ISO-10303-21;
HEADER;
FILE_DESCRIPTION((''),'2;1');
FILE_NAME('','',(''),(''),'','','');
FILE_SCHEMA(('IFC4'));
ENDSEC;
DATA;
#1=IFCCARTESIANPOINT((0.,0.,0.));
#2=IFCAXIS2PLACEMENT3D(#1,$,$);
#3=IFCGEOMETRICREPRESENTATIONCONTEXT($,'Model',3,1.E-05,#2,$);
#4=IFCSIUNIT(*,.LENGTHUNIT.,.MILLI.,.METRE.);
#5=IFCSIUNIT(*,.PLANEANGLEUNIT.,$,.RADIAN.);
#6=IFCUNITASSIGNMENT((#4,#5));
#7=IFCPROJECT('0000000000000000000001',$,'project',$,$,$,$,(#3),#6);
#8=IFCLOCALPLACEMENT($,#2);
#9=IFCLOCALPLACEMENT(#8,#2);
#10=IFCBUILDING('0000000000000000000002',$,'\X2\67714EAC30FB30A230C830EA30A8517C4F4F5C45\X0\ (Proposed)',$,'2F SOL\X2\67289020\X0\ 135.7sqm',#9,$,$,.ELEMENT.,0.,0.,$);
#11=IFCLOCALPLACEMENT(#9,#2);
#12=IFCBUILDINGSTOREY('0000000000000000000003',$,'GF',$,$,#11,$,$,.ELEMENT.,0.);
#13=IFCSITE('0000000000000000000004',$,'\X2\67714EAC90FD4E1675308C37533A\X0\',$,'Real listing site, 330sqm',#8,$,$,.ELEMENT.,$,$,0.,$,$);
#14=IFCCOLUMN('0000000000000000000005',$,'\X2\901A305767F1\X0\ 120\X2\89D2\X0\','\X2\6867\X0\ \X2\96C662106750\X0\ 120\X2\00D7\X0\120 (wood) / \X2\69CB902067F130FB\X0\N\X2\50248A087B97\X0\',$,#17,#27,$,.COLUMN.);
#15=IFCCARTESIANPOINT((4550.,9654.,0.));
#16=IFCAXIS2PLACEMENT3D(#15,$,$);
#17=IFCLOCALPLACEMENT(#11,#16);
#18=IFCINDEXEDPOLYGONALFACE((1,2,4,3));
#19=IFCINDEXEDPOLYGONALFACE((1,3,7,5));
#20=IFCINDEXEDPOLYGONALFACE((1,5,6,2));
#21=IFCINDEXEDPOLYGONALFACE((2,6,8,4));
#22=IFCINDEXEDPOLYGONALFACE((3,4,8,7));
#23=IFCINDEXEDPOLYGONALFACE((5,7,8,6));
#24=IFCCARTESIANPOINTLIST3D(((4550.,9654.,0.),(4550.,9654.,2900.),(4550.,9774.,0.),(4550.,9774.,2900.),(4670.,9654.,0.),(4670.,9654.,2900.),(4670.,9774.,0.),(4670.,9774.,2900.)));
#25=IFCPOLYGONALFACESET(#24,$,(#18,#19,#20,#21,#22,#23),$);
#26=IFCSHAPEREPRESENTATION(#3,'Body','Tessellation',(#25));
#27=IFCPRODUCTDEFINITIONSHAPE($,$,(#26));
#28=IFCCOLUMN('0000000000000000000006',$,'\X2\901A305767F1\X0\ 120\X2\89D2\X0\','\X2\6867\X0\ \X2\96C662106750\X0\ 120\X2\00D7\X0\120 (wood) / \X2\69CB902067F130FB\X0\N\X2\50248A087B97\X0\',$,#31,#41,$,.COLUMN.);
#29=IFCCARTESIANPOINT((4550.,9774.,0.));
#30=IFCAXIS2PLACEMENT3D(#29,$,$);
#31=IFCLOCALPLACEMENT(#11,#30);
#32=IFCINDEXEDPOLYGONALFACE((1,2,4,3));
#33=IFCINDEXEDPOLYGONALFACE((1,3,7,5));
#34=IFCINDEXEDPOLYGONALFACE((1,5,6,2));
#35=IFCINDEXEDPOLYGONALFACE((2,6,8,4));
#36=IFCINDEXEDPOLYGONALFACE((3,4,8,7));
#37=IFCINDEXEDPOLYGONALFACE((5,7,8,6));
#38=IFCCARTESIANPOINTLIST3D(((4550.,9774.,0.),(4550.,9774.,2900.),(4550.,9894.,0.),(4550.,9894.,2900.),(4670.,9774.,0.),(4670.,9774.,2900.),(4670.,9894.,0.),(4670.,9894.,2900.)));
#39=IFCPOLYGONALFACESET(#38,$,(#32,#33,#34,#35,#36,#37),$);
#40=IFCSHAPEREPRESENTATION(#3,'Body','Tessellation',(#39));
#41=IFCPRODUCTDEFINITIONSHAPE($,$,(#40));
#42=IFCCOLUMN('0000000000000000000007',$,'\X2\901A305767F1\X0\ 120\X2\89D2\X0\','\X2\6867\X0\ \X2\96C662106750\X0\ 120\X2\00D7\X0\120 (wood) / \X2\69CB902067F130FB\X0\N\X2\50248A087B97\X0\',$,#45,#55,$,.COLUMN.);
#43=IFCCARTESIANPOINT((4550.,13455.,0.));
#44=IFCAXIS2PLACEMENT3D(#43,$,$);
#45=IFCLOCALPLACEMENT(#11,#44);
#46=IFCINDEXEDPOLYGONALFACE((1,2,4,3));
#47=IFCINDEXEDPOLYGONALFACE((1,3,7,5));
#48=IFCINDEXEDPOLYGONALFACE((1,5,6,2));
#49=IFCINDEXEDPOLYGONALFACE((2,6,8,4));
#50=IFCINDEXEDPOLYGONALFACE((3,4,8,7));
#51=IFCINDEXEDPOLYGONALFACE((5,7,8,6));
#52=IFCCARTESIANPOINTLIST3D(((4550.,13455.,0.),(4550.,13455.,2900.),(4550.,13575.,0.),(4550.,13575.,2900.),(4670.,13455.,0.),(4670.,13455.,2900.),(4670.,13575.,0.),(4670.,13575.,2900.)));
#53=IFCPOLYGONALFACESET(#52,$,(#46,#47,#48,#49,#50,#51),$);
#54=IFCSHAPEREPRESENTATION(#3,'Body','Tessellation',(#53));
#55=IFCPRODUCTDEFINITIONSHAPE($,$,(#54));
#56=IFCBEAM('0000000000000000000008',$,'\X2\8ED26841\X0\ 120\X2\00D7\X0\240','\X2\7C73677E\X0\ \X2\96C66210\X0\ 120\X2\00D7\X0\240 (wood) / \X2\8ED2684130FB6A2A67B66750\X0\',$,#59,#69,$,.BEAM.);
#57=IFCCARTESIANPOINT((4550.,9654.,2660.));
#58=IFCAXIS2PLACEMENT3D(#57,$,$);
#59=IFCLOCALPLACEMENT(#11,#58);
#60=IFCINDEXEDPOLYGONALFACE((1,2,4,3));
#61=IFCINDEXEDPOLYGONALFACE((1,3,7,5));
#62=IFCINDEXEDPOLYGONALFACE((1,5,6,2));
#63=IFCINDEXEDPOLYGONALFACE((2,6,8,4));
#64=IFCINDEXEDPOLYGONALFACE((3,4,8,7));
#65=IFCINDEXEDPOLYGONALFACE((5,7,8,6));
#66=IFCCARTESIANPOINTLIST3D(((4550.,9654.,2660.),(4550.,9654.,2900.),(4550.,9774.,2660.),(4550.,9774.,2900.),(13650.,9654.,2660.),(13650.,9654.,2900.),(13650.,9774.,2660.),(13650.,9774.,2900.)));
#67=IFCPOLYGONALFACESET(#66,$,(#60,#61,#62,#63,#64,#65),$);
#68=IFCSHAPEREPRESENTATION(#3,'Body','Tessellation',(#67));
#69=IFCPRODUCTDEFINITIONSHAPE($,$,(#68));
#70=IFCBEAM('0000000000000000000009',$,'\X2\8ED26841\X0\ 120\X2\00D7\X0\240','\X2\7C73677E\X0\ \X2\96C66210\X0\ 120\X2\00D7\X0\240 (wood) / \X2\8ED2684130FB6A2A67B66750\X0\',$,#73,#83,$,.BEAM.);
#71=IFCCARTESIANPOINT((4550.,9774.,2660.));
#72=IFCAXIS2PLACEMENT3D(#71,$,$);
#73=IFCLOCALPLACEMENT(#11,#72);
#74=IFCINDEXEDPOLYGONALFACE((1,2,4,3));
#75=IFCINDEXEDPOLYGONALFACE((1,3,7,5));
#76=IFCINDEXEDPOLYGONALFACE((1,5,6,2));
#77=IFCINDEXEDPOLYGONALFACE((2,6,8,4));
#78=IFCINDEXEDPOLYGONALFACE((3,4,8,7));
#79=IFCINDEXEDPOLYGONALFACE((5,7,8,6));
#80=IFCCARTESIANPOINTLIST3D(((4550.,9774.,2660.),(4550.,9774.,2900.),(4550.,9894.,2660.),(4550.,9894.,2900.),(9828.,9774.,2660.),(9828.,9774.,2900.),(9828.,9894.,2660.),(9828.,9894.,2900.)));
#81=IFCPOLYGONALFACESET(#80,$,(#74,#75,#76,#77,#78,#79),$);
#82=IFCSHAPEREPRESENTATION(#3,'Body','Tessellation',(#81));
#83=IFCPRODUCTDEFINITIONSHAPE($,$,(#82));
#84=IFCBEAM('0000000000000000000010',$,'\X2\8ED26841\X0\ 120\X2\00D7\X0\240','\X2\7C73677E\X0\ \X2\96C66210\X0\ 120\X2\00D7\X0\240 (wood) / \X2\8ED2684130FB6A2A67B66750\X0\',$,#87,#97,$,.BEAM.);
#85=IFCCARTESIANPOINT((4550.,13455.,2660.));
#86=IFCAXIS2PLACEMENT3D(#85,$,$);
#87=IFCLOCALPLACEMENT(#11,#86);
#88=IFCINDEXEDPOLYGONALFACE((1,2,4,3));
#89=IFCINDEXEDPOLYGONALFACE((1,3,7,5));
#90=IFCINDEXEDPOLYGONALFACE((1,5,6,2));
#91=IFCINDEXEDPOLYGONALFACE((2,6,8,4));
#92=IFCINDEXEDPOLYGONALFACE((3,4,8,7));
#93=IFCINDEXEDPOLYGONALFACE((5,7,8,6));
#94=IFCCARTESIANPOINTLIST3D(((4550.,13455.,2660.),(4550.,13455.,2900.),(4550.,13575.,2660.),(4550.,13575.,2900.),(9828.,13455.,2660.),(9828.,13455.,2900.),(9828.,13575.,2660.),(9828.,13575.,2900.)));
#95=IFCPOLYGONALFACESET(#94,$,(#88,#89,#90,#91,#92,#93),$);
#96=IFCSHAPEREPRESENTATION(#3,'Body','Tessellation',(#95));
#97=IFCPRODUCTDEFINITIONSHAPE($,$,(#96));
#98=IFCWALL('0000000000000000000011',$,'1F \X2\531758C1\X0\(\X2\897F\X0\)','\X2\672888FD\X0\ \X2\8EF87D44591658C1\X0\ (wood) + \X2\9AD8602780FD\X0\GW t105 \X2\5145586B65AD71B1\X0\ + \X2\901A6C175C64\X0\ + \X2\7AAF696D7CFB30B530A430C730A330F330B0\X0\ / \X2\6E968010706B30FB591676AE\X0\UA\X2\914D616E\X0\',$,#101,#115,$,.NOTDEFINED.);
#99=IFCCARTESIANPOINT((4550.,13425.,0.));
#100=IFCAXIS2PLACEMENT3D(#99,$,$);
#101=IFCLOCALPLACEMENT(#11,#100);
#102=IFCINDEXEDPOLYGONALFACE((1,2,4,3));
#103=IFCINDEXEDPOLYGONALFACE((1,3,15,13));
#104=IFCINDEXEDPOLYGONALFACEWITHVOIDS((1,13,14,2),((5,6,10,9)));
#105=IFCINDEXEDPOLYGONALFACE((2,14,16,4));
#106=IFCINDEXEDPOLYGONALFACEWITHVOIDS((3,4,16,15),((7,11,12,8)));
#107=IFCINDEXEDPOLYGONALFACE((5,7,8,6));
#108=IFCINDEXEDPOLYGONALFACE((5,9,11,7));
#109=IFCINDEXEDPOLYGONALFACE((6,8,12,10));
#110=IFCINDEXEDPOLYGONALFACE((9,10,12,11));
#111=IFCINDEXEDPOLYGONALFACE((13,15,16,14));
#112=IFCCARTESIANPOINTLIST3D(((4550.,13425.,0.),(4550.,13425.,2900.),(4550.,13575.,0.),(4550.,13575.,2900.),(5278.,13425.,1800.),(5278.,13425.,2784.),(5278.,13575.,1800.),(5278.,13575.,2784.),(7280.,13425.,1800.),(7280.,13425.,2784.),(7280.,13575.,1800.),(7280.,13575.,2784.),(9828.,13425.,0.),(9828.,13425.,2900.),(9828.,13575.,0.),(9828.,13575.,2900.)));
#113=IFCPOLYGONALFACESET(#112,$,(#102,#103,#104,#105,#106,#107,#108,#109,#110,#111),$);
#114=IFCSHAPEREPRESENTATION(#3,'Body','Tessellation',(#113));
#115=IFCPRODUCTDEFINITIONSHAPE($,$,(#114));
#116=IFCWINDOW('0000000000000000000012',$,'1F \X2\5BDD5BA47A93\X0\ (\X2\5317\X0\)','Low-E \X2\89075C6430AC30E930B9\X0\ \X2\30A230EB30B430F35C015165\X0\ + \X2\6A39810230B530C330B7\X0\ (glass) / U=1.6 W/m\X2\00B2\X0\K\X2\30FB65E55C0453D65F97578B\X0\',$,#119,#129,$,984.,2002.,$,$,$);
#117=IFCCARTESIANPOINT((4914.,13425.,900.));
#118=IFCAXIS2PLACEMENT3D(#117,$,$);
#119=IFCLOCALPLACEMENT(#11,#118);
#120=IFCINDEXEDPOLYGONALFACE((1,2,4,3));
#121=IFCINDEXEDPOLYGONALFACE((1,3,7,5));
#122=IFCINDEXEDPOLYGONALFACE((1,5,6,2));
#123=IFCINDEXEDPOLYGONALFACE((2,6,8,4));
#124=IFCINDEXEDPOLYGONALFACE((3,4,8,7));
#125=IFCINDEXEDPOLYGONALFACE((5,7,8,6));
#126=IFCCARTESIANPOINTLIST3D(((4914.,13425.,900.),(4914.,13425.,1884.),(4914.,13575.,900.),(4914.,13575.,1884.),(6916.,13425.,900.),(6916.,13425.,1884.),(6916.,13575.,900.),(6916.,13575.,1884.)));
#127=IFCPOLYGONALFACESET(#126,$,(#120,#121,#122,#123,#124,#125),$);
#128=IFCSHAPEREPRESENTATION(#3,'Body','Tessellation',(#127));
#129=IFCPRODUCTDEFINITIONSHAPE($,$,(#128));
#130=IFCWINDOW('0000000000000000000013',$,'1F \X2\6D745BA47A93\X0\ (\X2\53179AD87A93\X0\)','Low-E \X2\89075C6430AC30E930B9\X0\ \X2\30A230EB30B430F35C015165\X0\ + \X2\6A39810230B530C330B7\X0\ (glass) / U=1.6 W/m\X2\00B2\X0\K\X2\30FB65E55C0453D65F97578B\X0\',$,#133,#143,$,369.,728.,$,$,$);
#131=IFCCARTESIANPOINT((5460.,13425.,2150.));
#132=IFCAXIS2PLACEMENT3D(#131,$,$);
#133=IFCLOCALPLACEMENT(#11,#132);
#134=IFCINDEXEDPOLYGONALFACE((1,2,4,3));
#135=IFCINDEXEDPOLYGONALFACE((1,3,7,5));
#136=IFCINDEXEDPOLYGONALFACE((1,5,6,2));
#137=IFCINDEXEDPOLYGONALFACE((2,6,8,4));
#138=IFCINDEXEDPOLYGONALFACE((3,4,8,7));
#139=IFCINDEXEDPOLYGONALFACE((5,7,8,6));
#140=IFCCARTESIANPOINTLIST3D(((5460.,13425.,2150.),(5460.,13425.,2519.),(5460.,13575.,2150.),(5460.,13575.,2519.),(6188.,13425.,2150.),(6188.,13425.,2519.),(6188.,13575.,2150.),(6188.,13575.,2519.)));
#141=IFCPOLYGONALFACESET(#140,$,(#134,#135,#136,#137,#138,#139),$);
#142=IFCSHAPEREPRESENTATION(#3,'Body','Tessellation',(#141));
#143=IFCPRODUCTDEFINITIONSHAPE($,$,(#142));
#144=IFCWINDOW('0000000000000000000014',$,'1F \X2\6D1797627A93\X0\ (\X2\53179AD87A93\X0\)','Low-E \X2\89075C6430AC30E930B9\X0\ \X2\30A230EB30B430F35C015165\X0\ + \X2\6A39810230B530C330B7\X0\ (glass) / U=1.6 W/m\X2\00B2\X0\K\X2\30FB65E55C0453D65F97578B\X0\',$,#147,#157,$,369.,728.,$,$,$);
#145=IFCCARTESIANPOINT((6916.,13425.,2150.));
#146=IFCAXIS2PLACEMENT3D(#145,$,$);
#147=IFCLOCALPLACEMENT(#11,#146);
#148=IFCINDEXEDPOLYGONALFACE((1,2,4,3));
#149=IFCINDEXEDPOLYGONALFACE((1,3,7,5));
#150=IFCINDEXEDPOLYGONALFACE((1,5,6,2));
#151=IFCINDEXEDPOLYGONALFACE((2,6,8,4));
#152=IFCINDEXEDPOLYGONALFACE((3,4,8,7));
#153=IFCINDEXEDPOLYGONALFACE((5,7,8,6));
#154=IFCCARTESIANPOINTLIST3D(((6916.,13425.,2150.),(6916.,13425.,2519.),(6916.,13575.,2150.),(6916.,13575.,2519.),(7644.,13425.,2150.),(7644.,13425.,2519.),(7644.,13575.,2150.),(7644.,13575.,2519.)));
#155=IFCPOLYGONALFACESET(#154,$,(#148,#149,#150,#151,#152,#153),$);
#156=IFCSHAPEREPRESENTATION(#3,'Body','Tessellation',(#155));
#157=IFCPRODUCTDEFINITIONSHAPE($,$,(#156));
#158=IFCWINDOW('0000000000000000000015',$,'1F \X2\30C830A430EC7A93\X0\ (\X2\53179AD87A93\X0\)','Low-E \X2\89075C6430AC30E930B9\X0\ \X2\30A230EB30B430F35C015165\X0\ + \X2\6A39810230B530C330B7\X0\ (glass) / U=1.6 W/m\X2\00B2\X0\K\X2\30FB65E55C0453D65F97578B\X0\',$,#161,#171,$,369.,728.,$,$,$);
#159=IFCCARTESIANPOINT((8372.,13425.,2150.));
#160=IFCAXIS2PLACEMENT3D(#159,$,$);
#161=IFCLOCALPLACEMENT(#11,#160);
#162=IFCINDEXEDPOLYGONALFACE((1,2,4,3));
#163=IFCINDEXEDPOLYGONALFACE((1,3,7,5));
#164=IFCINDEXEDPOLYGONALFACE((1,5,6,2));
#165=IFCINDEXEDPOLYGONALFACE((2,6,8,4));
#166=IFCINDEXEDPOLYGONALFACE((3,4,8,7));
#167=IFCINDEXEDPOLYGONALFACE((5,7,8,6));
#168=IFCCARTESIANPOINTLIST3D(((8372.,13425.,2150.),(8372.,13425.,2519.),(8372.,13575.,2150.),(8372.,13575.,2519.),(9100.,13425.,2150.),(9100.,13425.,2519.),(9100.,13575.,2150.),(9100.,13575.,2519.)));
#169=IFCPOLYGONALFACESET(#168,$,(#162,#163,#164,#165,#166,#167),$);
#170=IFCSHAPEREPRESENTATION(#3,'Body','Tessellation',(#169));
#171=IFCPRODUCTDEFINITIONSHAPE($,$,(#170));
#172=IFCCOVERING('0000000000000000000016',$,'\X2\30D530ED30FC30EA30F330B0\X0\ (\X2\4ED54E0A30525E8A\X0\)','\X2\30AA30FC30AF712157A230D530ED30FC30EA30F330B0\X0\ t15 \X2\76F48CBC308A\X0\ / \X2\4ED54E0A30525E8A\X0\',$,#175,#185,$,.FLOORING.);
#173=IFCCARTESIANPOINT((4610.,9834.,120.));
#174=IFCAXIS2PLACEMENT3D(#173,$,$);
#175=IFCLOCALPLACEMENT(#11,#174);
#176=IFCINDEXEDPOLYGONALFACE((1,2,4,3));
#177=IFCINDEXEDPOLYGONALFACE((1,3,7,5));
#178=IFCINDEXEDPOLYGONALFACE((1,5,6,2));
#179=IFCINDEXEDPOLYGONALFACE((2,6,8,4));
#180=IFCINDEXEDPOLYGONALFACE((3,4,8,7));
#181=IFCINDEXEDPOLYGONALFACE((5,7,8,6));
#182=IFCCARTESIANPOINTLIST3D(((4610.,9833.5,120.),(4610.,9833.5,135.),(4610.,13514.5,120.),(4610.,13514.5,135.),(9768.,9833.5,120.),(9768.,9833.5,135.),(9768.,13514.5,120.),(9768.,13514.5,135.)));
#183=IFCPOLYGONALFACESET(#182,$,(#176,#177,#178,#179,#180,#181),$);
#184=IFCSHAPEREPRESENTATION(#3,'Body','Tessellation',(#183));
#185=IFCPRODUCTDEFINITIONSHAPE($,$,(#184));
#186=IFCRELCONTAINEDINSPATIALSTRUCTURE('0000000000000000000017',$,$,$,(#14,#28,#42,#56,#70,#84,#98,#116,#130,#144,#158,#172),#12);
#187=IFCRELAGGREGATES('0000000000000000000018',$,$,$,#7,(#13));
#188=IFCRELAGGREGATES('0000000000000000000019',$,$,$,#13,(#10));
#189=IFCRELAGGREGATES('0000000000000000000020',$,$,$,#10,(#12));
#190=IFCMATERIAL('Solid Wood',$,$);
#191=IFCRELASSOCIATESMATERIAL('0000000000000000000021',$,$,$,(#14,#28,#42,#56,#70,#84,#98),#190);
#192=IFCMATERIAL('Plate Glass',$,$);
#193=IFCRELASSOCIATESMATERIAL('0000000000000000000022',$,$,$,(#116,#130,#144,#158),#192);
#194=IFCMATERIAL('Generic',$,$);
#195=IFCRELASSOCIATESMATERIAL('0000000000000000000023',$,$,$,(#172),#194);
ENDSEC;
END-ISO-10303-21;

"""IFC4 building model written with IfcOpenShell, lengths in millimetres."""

from ifc_helpers import new_model, si_unit, frame, frame_2d, origin, place, context, project, spatial, rectangle, extrude, material, element, fill, save


model = new_model("IFC4")

# Units and contexts
model_context = context("Model", 3, precision=1e-05, world=origin())
ifc_project = project(units=[si_unit("LENGTHUNIT", "METRE", prefix="MILLI"), si_unit("PLANEANGLEUNIT", "RADIAN")], contexts=[model_context])

# Site, building, storey
site_placement = place(None, origin())
site = spatial("IfcSite", under=ifc_project, at=site_placement, Name="東京都世田谷区", ObjectType="Real listing site, 330sqm", CompositionType="ELEMENT", RefElevation=0.0)
building_placement = place(site_placement, origin())
building = spatial("IfcBuilding", under=site, at=building_placement, Name="東京・アトリエ兼住居 (Proposed)", ObjectType="2F SOL木造 135.7sqm", CompositionType="ELEMENT", ElevationOfRefHeight=0.0, ElevationOfTerrain=0.0)
storey_placement = place(building_placement, origin())
storey = spatial("IfcBuildingStorey", under=building, at=storey_placement, Name="GF", CompositionType="ELEMENT", Elevation=0.0)

# Columns
ifc_material_1 = material(Name="Solid Wood")
column_1_placement = place(storey_placement, frame((4550.0, 9654.0, 0.0)))
element("IfcColumn", 1, at=column_1_placement, inside=storey, material=ifc_material_1, Name="通し柱 120角", Description="桧 集成材 120×120 (wood) / 構造柱・N値計算", PredefinedType="COLUMN", context=model_context, shape_type="SweptSolid", body=[
    extrude(rectangle(XDim=120.0, YDim=120.0, at=frame_2d((60.0, 60.0))), frame((4550.0, 9654.0, 0.0)), (0.0, 0.0, 1.0), 2900.0),
])
column_2_placement = place(storey_placement, frame((4550.0, 9774.0, 0.0)))
element("IfcColumn", 2, at=column_2_placement, inside=storey, material=ifc_material_1, Name="通し柱 120角", Description="桧 集成材 120×120 (wood) / 構造柱・N値計算", PredefinedType="COLUMN", context=model_context, shape_type="SweptSolid", body=[
    extrude(rectangle(XDim=120.0, YDim=120.0, at=frame_2d((60.0, 60.0))), frame((4550.0, 9774.0, 0.0)), (0.0, 0.0, 1.0), 2900.0),
])
column_3_placement = place(storey_placement, frame((4550.0, 13455.0, 0.0)))
element("IfcColumn", 3, at=column_3_placement, inside=storey, material=ifc_material_1, Name="通し柱 120角", Description="桧 集成材 120×120 (wood) / 構造柱・N値計算", PredefinedType="COLUMN", context=model_context, shape_type="SweptSolid", body=[
    extrude(rectangle(XDim=120.0, YDim=120.0, at=frame_2d((60.0, 60.0))), frame((4550.0, 13455.0, 0.0)), (0.0, 0.0, 1.0), 2900.0),
])

# Beams
beam_1_placement = place(storey_placement, frame((4550.0, 9654.0, 2660.0)))
element("IfcBeam", 4, at=beam_1_placement, inside=storey, material=ifc_material_1, Name="軒桁 120×240", Description="米松 集成 120×240 (wood) / 軒桁・横架材", PredefinedType="BEAM", context=model_context, shape_type="SweptSolid", body=[
    extrude(rectangle(XDim=9100.0, YDim=120.0, at=frame_2d((4550.0, 60.0))), frame((4550.0, 9654.0, 2660.0)), (0.0, 0.0, 1.0), 240.0),
])
beam_2_placement = place(storey_placement, frame((4550.0, 9774.0, 2660.0)))
element("IfcBeam", 5, at=beam_2_placement, inside=storey, material=ifc_material_1, Name="軒桁 120×240", Description="米松 集成 120×240 (wood) / 軒桁・横架材", PredefinedType="BEAM", context=model_context, shape_type="SweptSolid", body=[
    extrude(rectangle(XDim=5278.0, YDim=120.0, at=frame_2d((2639.0, 60.0))), frame((4550.0, 9774.0, 2660.0)), (0.0, 0.0, 1.0), 240.0),
])
beam_3_placement = place(storey_placement, frame((4550.0, 13455.0, 2660.0)))
element("IfcBeam", 6, at=beam_3_placement, inside=storey, material=ifc_material_1, Name="軒桁 120×240", Description="米松 集成 120×240 (wood) / 軒桁・横架材", PredefinedType="BEAM", context=model_context, shape_type="SweptSolid", body=[
    extrude(rectangle(XDim=5278.0, YDim=120.0, at=frame_2d((2639.0, 60.0))), frame((4550.0, 13455.0, 2660.0)), (0.0, 0.0, 1.0), 240.0),
])

# Wall, openings, windows
wall_1_placement = place(storey_placement, frame((4550.0, 13425.0, 0.0)))
wall_1 = element("IfcWall", 7, at=wall_1_placement, inside=storey, material=ifc_material_1, Name="1F 北壁(西)", Description="木製 軸組外壁 (wood) + 高性能GW t105 充填断熱 + 通気層 + 窯業系サイディング / 準耐火・外皮UA配慮", PredefinedType="NOTDEFINED", context=model_context, shape_type="SweptSolid", body=[
    extrude(rectangle(XDim=5278.0, YDim=150.0, at=frame_2d((2639.0, 75.0))), frame((4550.0, 13425.0, 0.0)), (0.0, 0.0, 1.0), 2900.0),
])
opening_1_placement = place(storey_placement, frame((4914.0, 13425.0, 900.0)))
opening_1 = element("IfcOpeningElement", 8, at=opening_1_placement, cuts=wall_1, PredefinedType="NOTDEFINED", context=model_context, shape_type="SweptSolid", body=[
    extrude(rectangle(XDim=2002.0, YDim=150.0, at=frame_2d((1001.0, 75.0))), frame((4914.0, 13425.0, 900.0)), (0.0, 0.0, 1.0), 984.0),
])
opening_2_placement = place(storey_placement, frame((5460.0, 13425.0, 2150.0)))
opening_2 = element("IfcOpeningElement", 9, at=opening_2_placement, cuts=wall_1, PredefinedType="NOTDEFINED", context=model_context, shape_type="SweptSolid", body=[
    extrude(rectangle(XDim=728.0, YDim=150.0, at=frame_2d((364.0, 75.0))), frame((5460.0, 13425.0, 2150.0)), (0.0, 0.0, 1.0), 369.0),
])
opening_3_placement = place(storey_placement, frame((6916.0, 13425.0, 2150.0)))
opening_3 = element("IfcOpeningElement", 10, at=opening_3_placement, cuts=wall_1, PredefinedType="NOTDEFINED", context=model_context, shape_type="SweptSolid", body=[
    extrude(rectangle(XDim=728.0, YDim=150.0, at=frame_2d((364.0, 75.0))), frame((6916.0, 13425.0, 2150.0)), (0.0, 0.0, 1.0), 369.0),
])
opening_4_placement = place(storey_placement, frame((8372.0, 13425.0, 2150.0)))
opening_4 = element("IfcOpeningElement", 11, at=opening_4_placement, cuts=wall_1, PredefinedType="NOTDEFINED", context=model_context, shape_type="SweptSolid", body=[
    extrude(rectangle(XDim=728.0, YDim=150.0, at=frame_2d((364.0, 75.0))), frame((8372.0, 13425.0, 2150.0)), (0.0, 0.0, 1.0), 369.0),
])
ifc_material_2 = material(Name="Plate Glass")
window_1_placement = place(storey_placement, frame((4914.0, 13425.0, 900.0)))
window_1 = element("IfcWindow", 12, at=window_1_placement, inside=storey, material=ifc_material_2, Name="1F 寝室窓 (北)", Description="Low-E 複層ガラス アルゴン封入 + 樹脂サッシ (glass) / U=1.6 W/m²K・日射取得型", OverallHeight=984.0, OverallWidth=2002.0, context=model_context, shape_type="SweptSolid", body=[
    extrude(rectangle(XDim=2002.0, YDim=150.0, at=frame_2d((1001.0, 75.0))), frame((4914.0, 13425.0, 900.0)), (0.0, 0.0, 1.0), 984.0),
])
fill(opening_1, window_1)
window_2_placement = place(storey_placement, frame((5460.0, 13425.0, 2150.0)))
window_2 = element("IfcWindow", 13, at=window_2_placement, inside=storey, material=ifc_material_2, Name="1F 浴室窓 (北高窓)", Description="Low-E 複層ガラス アルゴン封入 + 樹脂サッシ (glass) / U=1.6 W/m²K・日射取得型", OverallHeight=369.0, OverallWidth=728.0, context=model_context, shape_type="SweptSolid", body=[
    extrude(rectangle(XDim=728.0, YDim=150.0, at=frame_2d((364.0, 75.0))), frame((5460.0, 13425.0, 2150.0)), (0.0, 0.0, 1.0), 369.0),
])
fill(opening_2, window_2)
window_3_placement = place(storey_placement, frame((6916.0, 13425.0, 2150.0)))
window_3 = element("IfcWindow", 14, at=window_3_placement, inside=storey, material=ifc_material_2, Name="1F 洗面窓 (北高窓)", Description="Low-E 複層ガラス アルゴン封入 + 樹脂サッシ (glass) / U=1.6 W/m²K・日射取得型", OverallHeight=369.0, OverallWidth=728.0, context=model_context, shape_type="SweptSolid", body=[
    extrude(rectangle(XDim=728.0, YDim=150.0, at=frame_2d((364.0, 75.0))), frame((6916.0, 13425.0, 2150.0)), (0.0, 0.0, 1.0), 369.0),
])
fill(opening_3, window_3)
window_4_placement = place(storey_placement, frame((8372.0, 13425.0, 2150.0)))
window_4 = element("IfcWindow", 15, at=window_4_placement, inside=storey, material=ifc_material_2, Name="1F トイレ窓 (北高窓)", Description="Low-E 複層ガラス アルゴン封入 + 樹脂サッシ (glass) / U=1.6 W/m²K・日射取得型", OverallHeight=369.0, OverallWidth=728.0, context=model_context, shape_type="SweptSolid", body=[
    extrude(rectangle(XDim=728.0, YDim=150.0, at=frame_2d((364.0, 75.0))), frame((8372.0, 13425.0, 2150.0)), (0.0, 0.0, 1.0), 369.0),
])
fill(opening_4, window_4)

# Covering
ifc_material_3 = material(Name="Generic")
covering_placement = place(storey_placement, frame((4610.0, 9834.0, 120.0)))
element("IfcCovering", 16, at=covering_placement, inside=storey, material=ifc_material_3, Name="フローリング (仕上げ床)", Description="オーク無垢フローリング t15 直貼り / 仕上げ床", PredefinedType="FLOORING", context=model_context, shape_type="SweptSolid", body=[
    extrude(rectangle(XDim=5158.0, YDim=3681.0, at=frame_2d((2579.0, 1840.0))), frame((4610.0, 9834.0, 120.0)), (0.0, 0.0, 1.0), 15.0),
])

save(model, "model.ifc")
